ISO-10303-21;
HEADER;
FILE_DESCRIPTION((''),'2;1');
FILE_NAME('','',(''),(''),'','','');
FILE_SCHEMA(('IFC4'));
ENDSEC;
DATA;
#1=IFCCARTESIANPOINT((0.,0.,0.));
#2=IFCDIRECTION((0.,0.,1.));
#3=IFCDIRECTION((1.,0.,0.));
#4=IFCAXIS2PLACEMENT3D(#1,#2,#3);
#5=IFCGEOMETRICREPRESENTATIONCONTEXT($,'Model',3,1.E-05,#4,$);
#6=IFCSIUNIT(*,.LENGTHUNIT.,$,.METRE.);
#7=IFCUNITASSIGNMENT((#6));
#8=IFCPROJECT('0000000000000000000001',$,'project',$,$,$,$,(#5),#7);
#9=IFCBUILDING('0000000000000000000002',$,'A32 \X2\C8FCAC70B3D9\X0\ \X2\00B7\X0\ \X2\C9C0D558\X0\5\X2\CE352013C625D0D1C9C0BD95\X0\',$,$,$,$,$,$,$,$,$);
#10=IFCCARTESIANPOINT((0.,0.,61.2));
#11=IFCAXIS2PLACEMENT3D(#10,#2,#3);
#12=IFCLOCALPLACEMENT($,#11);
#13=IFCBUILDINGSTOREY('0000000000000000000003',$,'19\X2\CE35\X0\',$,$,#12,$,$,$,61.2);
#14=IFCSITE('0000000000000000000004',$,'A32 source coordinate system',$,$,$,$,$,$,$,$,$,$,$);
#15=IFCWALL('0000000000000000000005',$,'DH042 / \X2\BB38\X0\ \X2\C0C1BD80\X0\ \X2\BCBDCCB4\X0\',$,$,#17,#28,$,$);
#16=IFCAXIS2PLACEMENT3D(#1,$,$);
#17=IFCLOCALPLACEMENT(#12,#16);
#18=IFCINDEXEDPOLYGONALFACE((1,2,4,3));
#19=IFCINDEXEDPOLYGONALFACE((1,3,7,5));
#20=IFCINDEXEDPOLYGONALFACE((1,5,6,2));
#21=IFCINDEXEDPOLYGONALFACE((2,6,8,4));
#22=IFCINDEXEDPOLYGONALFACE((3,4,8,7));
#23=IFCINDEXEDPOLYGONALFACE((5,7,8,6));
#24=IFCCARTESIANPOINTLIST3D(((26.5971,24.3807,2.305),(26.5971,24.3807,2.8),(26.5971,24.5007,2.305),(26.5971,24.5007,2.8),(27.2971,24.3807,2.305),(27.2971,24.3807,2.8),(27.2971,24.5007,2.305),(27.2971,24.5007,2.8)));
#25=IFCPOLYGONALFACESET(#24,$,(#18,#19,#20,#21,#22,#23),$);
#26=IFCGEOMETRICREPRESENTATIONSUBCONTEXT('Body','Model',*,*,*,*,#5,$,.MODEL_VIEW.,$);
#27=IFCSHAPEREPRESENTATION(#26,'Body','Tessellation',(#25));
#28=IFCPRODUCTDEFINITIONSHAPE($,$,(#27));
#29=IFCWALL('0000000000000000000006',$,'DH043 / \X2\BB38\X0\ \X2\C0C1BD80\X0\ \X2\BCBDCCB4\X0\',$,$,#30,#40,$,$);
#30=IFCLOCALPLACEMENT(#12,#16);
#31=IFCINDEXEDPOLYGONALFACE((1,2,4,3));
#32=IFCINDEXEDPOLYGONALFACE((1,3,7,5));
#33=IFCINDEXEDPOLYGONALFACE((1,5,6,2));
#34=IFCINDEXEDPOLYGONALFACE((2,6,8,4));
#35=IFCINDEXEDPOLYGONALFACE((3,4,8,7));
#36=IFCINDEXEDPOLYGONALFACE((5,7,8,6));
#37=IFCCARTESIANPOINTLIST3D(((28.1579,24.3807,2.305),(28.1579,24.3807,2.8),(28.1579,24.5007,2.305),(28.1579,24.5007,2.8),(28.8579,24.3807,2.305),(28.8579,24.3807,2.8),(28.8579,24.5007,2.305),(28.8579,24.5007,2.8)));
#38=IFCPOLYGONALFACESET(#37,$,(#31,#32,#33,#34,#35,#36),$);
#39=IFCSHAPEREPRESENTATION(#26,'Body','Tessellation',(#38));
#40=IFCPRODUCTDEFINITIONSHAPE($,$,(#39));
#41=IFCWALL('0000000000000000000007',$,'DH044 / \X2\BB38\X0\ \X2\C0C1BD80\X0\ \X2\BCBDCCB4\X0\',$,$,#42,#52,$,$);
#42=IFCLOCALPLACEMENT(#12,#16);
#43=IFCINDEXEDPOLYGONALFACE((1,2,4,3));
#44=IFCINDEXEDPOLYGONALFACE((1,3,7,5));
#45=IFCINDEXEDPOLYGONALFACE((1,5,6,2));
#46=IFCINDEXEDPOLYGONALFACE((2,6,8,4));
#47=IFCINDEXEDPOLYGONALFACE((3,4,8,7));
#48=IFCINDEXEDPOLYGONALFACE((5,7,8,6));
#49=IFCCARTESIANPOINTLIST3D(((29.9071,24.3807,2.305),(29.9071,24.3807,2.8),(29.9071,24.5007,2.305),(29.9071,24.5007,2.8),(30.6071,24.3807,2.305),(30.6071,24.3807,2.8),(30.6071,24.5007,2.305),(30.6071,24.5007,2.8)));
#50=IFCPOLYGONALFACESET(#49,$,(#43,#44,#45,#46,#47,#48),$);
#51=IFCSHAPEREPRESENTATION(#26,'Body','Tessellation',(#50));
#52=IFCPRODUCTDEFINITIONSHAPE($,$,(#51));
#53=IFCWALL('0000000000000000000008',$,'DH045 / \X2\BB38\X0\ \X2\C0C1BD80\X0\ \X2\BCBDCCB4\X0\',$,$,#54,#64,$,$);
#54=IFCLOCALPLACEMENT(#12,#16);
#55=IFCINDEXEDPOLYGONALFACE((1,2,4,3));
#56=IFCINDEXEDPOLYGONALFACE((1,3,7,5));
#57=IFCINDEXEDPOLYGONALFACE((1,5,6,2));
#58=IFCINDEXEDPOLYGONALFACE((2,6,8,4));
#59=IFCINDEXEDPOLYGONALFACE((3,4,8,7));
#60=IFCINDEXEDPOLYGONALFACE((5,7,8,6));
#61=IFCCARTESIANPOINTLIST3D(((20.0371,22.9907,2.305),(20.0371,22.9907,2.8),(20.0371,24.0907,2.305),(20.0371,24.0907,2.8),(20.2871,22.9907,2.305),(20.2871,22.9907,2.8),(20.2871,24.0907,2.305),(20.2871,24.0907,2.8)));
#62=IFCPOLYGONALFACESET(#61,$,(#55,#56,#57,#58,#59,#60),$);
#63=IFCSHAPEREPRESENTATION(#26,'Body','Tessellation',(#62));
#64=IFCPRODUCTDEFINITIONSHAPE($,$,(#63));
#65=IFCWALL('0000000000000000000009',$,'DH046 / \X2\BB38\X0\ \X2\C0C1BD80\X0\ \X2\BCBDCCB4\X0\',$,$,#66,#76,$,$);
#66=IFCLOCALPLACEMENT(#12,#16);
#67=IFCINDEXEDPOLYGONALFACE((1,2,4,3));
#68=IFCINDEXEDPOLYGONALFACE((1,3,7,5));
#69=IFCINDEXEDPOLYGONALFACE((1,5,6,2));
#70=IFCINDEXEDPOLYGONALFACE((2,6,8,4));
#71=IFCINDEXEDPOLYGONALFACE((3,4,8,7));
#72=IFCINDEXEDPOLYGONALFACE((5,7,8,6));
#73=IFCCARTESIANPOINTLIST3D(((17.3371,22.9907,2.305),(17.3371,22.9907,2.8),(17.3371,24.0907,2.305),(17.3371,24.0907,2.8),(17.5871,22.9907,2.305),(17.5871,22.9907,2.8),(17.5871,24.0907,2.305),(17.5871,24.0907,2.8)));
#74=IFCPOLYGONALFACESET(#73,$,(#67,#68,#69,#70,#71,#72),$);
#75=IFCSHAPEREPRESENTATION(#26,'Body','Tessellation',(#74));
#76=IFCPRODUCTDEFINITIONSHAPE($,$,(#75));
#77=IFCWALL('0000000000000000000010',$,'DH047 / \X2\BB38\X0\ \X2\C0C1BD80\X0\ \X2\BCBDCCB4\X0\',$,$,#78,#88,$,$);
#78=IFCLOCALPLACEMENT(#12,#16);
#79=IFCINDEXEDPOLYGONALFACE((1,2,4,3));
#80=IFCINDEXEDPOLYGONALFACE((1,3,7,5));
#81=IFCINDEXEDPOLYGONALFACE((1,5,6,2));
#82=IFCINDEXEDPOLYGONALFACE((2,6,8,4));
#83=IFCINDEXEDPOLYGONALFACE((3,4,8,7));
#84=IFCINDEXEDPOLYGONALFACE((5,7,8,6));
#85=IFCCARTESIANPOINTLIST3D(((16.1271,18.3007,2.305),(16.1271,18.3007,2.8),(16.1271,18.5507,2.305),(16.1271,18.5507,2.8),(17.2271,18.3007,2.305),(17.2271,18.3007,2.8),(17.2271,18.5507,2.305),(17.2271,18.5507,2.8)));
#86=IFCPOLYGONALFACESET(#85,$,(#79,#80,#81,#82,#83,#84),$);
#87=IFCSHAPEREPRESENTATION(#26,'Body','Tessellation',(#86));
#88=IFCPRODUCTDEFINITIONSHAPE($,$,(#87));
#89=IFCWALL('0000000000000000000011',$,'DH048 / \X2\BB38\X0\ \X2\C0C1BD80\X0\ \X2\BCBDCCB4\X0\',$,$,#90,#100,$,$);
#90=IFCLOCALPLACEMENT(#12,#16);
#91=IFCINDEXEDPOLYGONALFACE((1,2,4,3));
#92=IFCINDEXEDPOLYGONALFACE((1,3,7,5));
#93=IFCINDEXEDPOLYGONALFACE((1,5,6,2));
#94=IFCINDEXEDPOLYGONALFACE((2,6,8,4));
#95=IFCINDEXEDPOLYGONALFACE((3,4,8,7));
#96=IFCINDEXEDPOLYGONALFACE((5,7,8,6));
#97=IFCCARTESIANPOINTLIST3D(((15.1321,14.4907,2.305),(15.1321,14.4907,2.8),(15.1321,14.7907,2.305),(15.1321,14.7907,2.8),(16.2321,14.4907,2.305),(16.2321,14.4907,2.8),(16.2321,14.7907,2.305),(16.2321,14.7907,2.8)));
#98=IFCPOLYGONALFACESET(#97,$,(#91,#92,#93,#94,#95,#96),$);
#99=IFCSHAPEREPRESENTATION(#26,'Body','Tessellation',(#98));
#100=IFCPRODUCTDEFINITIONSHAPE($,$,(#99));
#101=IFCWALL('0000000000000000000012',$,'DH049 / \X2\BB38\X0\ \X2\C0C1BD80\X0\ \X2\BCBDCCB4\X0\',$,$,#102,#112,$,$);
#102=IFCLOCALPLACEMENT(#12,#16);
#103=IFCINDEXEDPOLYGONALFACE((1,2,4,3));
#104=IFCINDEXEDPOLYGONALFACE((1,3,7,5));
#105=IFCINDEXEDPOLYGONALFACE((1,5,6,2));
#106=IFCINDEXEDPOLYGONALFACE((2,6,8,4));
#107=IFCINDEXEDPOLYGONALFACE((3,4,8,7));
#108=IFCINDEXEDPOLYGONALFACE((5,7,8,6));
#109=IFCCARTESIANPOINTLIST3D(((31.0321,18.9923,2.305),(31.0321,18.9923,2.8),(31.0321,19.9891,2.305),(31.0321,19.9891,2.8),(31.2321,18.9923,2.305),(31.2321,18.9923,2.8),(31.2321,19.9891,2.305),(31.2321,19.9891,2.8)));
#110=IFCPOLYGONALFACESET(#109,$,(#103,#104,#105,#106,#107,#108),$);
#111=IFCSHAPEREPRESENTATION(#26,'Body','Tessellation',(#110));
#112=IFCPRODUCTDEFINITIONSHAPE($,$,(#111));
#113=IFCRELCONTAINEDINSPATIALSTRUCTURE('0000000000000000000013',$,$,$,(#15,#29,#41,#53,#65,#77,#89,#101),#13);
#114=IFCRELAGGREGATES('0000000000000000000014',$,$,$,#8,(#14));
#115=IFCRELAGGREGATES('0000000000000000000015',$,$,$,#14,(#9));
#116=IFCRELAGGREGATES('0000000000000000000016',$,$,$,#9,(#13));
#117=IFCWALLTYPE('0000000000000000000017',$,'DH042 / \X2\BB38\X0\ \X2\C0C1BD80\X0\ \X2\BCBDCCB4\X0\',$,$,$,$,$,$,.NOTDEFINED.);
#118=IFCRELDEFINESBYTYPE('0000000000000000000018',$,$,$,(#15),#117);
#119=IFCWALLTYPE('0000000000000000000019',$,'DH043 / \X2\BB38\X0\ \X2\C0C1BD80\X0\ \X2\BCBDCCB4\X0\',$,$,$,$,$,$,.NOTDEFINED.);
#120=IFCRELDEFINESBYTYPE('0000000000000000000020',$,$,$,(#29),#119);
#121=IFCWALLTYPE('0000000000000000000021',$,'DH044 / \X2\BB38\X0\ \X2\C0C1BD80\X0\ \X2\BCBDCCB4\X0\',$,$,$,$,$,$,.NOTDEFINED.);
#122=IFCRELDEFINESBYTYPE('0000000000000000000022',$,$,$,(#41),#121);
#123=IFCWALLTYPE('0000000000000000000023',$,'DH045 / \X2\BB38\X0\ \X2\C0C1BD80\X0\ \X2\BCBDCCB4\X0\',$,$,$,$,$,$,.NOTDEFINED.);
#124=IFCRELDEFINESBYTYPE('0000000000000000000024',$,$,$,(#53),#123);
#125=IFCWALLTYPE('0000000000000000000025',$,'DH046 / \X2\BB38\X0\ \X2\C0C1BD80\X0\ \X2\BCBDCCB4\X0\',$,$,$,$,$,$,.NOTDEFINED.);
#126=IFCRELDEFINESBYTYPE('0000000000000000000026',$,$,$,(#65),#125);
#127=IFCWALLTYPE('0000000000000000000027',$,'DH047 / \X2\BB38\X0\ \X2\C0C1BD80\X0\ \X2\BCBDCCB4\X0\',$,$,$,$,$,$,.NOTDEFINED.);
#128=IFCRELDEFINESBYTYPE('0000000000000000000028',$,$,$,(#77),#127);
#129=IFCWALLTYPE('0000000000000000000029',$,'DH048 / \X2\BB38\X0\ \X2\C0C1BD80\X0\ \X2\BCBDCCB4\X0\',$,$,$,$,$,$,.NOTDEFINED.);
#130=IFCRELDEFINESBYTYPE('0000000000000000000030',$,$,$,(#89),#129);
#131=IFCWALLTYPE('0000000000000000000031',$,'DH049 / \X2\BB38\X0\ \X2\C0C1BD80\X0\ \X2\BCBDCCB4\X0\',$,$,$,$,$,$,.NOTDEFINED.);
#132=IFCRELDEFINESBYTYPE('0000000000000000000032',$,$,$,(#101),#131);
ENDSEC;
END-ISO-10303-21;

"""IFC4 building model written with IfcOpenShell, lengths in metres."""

from ifc_helpers import new_model, si_unit, frame, origin, origin_with_axes, place, context, subcontext, project, spatial, polyline, outline, extrude, source, transform, mapped, type_object, type_shapes, element, save


model = new_model("IFC4")

# Units and contexts
model_context = context("Model", 3, precision=1e-05, world=origin_with_axes())
body_context = subcontext(model_context, "Body", "Model", "MODEL_VIEW")
ifc_project = project(units=[si_unit("LENGTHUNIT", "METRE")], contexts=[model_context])

# Site, building, storey
site = spatial("IfcSite", under=ifc_project, Name="A32 source coordinate system")
building = spatial("IfcBuilding", under=site, Name="A32 주거동 · 지하5층–옥탑지붕")
storey_placement = place(None, frame((0.0, 0.0, 61.2), z_axis=(0.0, 0.0, 1.0), x_axis=(1.0, 0.0, 0.0)))
storey = spatial("IfcBuildingStorey", under=building, at=storey_placement, Name="19층", Elevation=61.2)

# Walls
wall_type_1 = type_object("IfcWallType", Name="DH042 / 문 상부 벽체", PredefinedType="NOTDEFINED")
shared_shape_1 = source(origin(), body_context, "Body", "SweptSolid", [
    extrude(outline(polyline([(27.2971, 24.3807), (26.5971, 24.3807), (26.5971, 24.5007), (27.2971, 24.5007), (27.2971, 24.3807)])), frame((0.0, 0.0, 2.305)), (0.0, 0.0, 1.0), 0.495),
])
type_shapes(wall_type_1, [shared_shape_1])
wall_1_placement = place(storey_placement, origin_with_axes())
element("IfcWall", 1, at=wall_1_placement, inside=storey, type_object=wall_type_1, Name="DH042 / 문 상부 벽체", context=body_context, shape_type="MappedRepresentation", body=[
    mapped(shared_shape_1, transform((0.0, 0.0, 0.0), scale=1.0)),
])
wall_type_2 = type_object("IfcWallType", Name="DH043 / 문 상부 벽체", PredefinedType="NOTDEFINED")
shared_shape_2 = source(origin(), body_context, "Body", "SweptSolid", [
    extrude(outline(polyline([(28.8579, 24.3807), (28.1579, 24.3807), (28.1579, 24.5007), (28.8579, 24.5007), (28.8579, 24.3807)])), frame((0.0, 0.0, 2.305)), (0.0, 0.0, 1.0), 0.495),
])
type_shapes(wall_type_2, [shared_shape_2])
wall_2_placement = place(storey_placement, origin_with_axes())
element("IfcWall", 2, at=wall_2_placement, inside=storey, type_object=wall_type_2, Name="DH043 / 문 상부 벽체", context=body_context, shape_type="MappedRepresentation", body=[
    mapped(shared_shape_2, transform((0.0, 0.0, 0.0), scale=1.0)),
])
wall_type_3 = type_object("IfcWallType", Name="DH044 / 문 상부 벽체", PredefinedType="NOTDEFINED")
shared_shape_3 = source(origin(), body_context, "Body", "SweptSolid", [
    extrude(outline(polyline([(30.6071, 24.3807), (29.9071, 24.3807), (29.9071, 24.5007), (30.6071, 24.5007), (30.6071, 24.3807)])), frame((0.0, 0.0, 2.305)), (0.0, 0.0, 1.0), 0.495),
])
type_shapes(wall_type_3, [shared_shape_3])
wall_3_placement = place(storey_placement, origin_with_axes())
element("IfcWall", 3, at=wall_3_placement, inside=storey, type_object=wall_type_3, Name="DH044 / 문 상부 벽체", context=body_context, shape_type="MappedRepresentation", body=[
    mapped(shared_shape_3, transform((0.0, 0.0, 0.0), scale=1.0)),
])
wall_type_4 = type_object("IfcWallType", Name="DH045 / 문 상부 벽체", PredefinedType="NOTDEFINED")
shared_shape_4 = source(origin(), body_context, "Body", "SweptSolid", [
    extrude(outline(polyline([(20.2871, 22.9907), (20.0371, 22.9907), (20.0371, 24.0907), (20.2871, 24.0907), (20.2871, 22.9907)])), frame((0.0, 0.0, 2.305)), (0.0, 0.0, 1.0), 0.495),
])
type_shapes(wall_type_4, [shared_shape_4])
wall_4_placement = place(storey_placement, origin_with_axes())
element("IfcWall", 4, at=wall_4_placement, inside=storey, type_object=wall_type_4, Name="DH045 / 문 상부 벽체", context=body_context, shape_type="MappedRepresentation", body=[
    mapped(shared_shape_4, transform((0.0, 0.0, 0.0), scale=1.0)),
])
wall_type_5 = type_object("IfcWallType", Name="DH046 / 문 상부 벽체", PredefinedType="NOTDEFINED")
shared_shape_5 = source(origin(), body_context, "Body", "SweptSolid", [
    extrude(outline(polyline([(17.5871, 22.9907), (17.3371, 22.9907), (17.3371, 24.0907), (17.5871, 24.0907), (17.5871, 22.9907)])), frame((0.0, 0.0, 2.305)), (0.0, 0.0, 1.0), 0.495),
])
type_shapes(wall_type_5, [shared_shape_5])
wall_5_placement = place(storey_placement, origin_with_axes())
element("IfcWall", 5, at=wall_5_placement, inside=storey, type_object=wall_type_5, Name="DH046 / 문 상부 벽체", context=body_context, shape_type="MappedRepresentation", body=[
    mapped(shared_shape_5, transform((0.0, 0.0, 0.0), scale=1.0)),
])
wall_type_6 = type_object("IfcWallType", Name="DH047 / 문 상부 벽체", PredefinedType="NOTDEFINED")
shared_shape_6 = source(origin(), body_context, "Body", "SweptSolid", [
    extrude(outline(polyline([(17.2271, 18.3007), (16.1271, 18.3007), (16.1271, 18.5507), (17.2271, 18.5507), (17.2271, 18.3007)])), frame((0.0, 0.0, 2.305)), (0.0, 0.0, 1.0), 0.495),
])
type_shapes(wall_type_6, [shared_shape_6])
wall_6_placement = place(storey_placement, origin_with_axes())
element("IfcWall", 6, at=wall_6_placement, inside=storey, type_object=wall_type_6, Name="DH047 / 문 상부 벽체", context=body_context, shape_type="MappedRepresentation", body=[
    mapped(shared_shape_6, transform((0.0, 0.0, 0.0), scale=1.0)),
])
wall_type_7 = type_object("IfcWallType", Name="DH048 / 문 상부 벽체", PredefinedType="NOTDEFINED")
shared_shape_7 = source(origin(), body_context, "Body", "SweptSolid", [
    extrude(outline(polyline([(15.1321, 14.7907), (16.2321, 14.7907), (16.2321, 14.4907), (15.1321, 14.4907), (15.1321, 14.7907)])), frame((0.0, 0.0, 2.305)), (0.0, 0.0, 1.0), 0.495),
])
type_shapes(wall_type_7, [shared_shape_7])
wall_7_placement = place(storey_placement, origin_with_axes())
element("IfcWall", 7, at=wall_7_placement, inside=storey, type_object=wall_type_7, Name="DH048 / 문 상부 벽체", context=body_context, shape_type="MappedRepresentation", body=[
    mapped(shared_shape_7, transform((0.0, 0.0, 0.0), scale=1.0)),
])
wall_type_8 = type_object("IfcWallType", Name="DH049 / 문 상부 벽체", PredefinedType="NOTDEFINED")
shared_shape_8 = source(origin(), body_context, "Body", "SweptSolid", [
    extrude(outline(polyline([(31.2321, 18.9923), (31.0321, 18.9923), (31.0321, 19.9891), (31.2321, 19.9891), (31.2321, 18.9923)])), frame((0.0, 0.0, 2.305)), (0.0, 0.0, 1.0), 0.495),
])
type_shapes(wall_type_8, [shared_shape_8])
wall_8_placement = place(storey_placement, origin_with_axes())
element("IfcWall", 8, at=wall_8_placement, inside=storey, type_object=wall_type_8, Name="DH049 / 문 상부 벽체", context=body_context, shape_type="MappedRepresentation", body=[
    mapped(shared_shape_8, transform((0.0, 0.0, 0.0), scale=1.0)),
])

save(model, "model.ifc")
